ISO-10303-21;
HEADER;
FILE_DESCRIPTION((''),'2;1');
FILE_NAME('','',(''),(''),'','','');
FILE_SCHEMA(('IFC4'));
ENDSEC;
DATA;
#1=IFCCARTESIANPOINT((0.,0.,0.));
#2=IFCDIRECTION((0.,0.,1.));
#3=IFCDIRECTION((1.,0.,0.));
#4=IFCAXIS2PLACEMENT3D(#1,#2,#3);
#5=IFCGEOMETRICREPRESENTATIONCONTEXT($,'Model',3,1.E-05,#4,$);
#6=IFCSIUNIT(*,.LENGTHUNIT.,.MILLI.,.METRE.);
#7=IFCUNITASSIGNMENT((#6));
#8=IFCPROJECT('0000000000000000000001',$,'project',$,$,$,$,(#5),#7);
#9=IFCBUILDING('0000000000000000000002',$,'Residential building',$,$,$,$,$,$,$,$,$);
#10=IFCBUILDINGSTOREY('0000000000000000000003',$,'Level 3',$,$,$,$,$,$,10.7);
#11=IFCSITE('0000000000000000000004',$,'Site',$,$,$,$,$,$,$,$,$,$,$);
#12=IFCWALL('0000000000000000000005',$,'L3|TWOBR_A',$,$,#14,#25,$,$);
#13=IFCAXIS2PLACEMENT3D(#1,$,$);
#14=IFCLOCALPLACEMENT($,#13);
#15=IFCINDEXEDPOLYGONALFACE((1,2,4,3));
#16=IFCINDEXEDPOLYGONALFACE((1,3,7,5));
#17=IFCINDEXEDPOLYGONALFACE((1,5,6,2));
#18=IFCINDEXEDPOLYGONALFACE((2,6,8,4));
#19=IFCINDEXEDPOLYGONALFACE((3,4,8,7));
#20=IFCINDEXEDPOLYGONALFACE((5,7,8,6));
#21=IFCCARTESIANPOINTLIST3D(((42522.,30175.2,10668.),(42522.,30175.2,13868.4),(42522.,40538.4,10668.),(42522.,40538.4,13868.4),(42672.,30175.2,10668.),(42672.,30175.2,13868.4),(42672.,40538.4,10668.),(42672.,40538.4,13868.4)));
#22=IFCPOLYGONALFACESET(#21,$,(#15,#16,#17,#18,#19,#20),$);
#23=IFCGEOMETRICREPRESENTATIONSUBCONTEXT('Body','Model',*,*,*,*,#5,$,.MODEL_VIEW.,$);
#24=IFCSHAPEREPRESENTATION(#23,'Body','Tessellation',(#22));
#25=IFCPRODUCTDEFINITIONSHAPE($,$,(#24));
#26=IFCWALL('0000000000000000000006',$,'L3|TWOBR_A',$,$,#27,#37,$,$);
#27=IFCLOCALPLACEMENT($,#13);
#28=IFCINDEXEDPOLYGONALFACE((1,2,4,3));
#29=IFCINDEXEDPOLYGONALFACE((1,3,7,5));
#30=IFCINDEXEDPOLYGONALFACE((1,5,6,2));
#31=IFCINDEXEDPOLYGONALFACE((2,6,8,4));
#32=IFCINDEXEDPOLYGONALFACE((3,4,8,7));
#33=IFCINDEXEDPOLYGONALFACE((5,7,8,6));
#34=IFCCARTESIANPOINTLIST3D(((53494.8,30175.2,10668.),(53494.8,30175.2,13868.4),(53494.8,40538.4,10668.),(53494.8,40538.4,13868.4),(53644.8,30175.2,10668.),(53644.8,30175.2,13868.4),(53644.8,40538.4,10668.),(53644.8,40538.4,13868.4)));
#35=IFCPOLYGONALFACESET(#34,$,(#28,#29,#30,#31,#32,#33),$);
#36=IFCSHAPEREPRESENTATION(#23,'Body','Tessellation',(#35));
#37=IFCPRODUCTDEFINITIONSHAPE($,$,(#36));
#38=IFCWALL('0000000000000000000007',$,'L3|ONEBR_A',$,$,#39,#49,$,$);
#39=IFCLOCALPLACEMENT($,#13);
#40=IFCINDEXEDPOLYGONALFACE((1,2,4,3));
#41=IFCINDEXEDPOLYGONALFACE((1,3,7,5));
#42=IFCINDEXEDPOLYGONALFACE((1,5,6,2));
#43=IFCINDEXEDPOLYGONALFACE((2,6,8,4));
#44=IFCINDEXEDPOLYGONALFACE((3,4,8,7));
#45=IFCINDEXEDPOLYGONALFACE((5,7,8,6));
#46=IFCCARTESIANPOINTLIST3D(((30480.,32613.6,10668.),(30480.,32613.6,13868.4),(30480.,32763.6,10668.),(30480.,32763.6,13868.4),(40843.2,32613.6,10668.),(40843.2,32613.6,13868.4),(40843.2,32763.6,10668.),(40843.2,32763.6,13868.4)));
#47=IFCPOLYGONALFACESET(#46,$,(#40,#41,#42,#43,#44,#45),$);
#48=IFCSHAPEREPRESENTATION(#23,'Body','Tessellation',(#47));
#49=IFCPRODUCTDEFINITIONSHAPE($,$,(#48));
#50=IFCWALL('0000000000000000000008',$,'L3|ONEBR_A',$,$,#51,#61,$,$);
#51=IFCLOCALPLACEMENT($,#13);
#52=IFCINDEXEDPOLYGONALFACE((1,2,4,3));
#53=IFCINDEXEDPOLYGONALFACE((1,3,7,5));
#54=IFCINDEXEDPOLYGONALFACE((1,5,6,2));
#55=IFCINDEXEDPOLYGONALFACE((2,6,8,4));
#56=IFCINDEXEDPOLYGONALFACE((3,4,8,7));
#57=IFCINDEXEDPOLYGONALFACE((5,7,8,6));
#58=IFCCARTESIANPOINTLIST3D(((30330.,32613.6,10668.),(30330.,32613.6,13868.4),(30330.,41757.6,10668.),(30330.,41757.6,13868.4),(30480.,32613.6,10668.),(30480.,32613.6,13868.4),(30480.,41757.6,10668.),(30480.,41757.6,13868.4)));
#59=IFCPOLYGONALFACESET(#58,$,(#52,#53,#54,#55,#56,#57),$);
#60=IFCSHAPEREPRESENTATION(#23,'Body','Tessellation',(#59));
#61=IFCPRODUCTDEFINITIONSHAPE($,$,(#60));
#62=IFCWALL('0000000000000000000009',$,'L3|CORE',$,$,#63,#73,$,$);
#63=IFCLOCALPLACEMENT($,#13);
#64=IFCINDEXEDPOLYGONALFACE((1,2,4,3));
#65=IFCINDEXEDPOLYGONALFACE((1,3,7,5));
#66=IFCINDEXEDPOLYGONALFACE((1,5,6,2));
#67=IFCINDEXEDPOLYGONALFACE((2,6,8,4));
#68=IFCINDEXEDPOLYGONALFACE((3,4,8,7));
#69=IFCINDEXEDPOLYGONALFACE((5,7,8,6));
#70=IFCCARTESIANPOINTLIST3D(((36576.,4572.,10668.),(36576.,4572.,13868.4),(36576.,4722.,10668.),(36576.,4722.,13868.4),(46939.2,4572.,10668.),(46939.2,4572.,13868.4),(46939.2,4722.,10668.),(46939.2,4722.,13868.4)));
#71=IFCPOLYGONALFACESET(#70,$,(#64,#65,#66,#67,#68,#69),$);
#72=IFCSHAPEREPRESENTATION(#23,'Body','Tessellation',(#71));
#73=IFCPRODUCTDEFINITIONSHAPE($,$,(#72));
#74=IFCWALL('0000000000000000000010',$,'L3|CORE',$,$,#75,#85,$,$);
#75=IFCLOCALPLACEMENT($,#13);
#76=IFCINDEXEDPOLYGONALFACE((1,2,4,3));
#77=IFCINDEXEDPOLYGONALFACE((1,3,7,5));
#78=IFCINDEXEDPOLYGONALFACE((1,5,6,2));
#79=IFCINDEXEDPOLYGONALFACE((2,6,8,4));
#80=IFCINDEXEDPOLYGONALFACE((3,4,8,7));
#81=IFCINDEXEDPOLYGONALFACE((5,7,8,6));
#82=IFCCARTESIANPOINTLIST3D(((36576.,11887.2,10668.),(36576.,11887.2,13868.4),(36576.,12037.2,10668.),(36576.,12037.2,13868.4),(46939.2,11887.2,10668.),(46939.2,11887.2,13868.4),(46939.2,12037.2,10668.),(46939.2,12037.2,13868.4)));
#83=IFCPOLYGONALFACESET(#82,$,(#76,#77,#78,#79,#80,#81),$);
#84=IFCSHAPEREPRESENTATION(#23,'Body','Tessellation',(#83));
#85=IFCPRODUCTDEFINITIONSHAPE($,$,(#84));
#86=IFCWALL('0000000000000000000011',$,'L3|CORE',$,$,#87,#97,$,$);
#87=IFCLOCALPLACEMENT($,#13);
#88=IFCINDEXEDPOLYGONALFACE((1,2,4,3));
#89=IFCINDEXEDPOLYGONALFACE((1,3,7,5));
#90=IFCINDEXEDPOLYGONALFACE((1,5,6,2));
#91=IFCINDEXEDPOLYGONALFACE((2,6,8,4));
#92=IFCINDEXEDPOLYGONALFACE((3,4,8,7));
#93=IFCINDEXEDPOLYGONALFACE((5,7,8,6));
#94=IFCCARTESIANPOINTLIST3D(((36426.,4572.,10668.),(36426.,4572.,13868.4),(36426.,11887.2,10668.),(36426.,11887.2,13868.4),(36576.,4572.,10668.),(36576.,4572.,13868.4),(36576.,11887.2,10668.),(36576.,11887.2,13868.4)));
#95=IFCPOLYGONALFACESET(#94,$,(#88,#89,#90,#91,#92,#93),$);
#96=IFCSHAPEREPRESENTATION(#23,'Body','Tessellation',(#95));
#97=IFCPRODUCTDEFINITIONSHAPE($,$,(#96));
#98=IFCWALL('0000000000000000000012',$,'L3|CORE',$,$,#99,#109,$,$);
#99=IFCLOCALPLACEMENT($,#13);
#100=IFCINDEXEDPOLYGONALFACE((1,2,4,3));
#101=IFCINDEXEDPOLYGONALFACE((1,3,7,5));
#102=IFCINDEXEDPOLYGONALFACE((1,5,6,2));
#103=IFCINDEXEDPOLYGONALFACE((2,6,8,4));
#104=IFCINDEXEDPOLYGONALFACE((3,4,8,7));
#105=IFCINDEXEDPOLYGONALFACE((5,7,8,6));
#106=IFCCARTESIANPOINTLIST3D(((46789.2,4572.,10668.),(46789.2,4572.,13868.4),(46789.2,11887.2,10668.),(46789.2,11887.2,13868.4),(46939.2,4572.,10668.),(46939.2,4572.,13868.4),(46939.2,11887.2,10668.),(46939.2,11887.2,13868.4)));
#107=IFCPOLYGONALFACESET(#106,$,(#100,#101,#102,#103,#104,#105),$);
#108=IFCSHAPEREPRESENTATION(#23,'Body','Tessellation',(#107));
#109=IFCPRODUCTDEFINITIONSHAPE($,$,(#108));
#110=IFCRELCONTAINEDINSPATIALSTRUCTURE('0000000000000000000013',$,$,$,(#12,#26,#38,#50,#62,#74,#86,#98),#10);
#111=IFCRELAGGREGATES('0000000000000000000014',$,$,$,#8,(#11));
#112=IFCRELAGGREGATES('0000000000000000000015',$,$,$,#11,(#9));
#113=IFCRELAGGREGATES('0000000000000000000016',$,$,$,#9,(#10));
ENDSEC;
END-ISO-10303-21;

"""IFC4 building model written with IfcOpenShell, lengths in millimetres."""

from ifc_helpers import new_model, si_unit, frame, origin_with_axes, place, context, subcontext, project, spatial, indexed_curve, outline, extrude, element, save


model = new_model("IFC4")

# Units and contexts
model_context = context("Model", 3, precision=1e-05, world=origin_with_axes())
body_context = subcontext(model_context, "Body", "Model", "MODEL_VIEW")
ifc_project = project(units=[si_unit("LENGTHUNIT", "METRE", prefix="MILLI")], contexts=[model_context])

# Site, building, storey
site = spatial("IfcSite", under=ifc_project, Name="Site")
building = spatial("IfcBuilding", under=site, Name="Residential building")
storey = spatial("IfcBuildingStorey", under=building, Name="Level 3", Elevation=10.7)

# Walls
for number, where, z_axis, x_axis, name in (
    (1, (42672.0, 30175.2, 10668.0), (0.0, 0.0, 1.0), (0.0, 1.0, 0.0), "L3|TWOBR_A"),
    (2, (53644.8, 30175.2, 10668.0), (0.0, 0.0, 1.0), (0.0, 1.0, 0.0), "L3|TWOBR_A"),
    (3, (30480.0, 32613.6, 10668.0), (0.0, 0.0, 1.0), (1.0, 0.0, 0.0), "L3|ONEBR_A"),
):
    element("IfcWall", number, at=place(None, frame(where, z_axis=z_axis, x_axis=x_axis)), inside=storey, Name=name, context=body_context, shape_type="SweptSolid", body=[
        extrude(outline(indexed_curve([(0.0, 0.0), (0.0, 150.0), (10363.2, 150.0), (10363.2, 0.0), (0.0, 0.0)], self_intersect=False)), origin_with_axes(), (0.0, 0.0, 1.0), 3200.4),
    ])
wall_1_placement = place(None, frame((30480.0, 32613.6, 10668.0), z_axis=(0.0, 0.0, 1.0), x_axis=(0.0, 1.0, 0.0)))
element("IfcWall", 4, at=wall_1_placement, inside=storey, Name="L3|ONEBR_A", context=body_context, shape_type="SweptSolid", body=[
    extrude(outline(indexed_curve([(0.0, 0.0), (0.0, 150.0), (9144.0, 150.0), (9144.0, 0.0), (0.0, 0.0)], self_intersect=False)), origin_with_axes(), (0.0, 0.0, 1.0), 3200.4),
])
for number, where, z_axis, x_axis, name in (
    (5, (36576.0, 4572.0, 10668.0), (0.0, 0.0, 1.0), (1.0, 0.0, 0.0), "L3|CORE"),
    (6, (36576.0, 11887.2, 10668.0), (0.0, 0.0, 1.0), (1.0, 0.0, 0.0), "L3|CORE"),
):
    element("IfcWall", number, at=place(None, frame(where, z_axis=z_axis, x_axis=x_axis)), inside=storey, Name=name, context=body_context, shape_type="SweptSolid", body=[
        extrude(outline(indexed_curve([(0.0, 0.0), (0.0, 150.0), (10363.2, 150.0), (10363.2, 0.0), (0.0, 0.0)], self_intersect=False)), origin_with_axes(), (0.0, 0.0, 1.0), 3200.4),
    ])
for number, where, z_axis, x_axis, name in (
    (7, (36576.0, 4572.0, 10668.0), (0.0, 0.0, 1.0), (0.0, 1.0, 0.0), "L3|CORE"),
    (8, (46939.2, 4572.0, 10668.0), (0.0, 0.0, 1.0), (0.0, 1.0, 0.0), "L3|CORE"),
):
    element("IfcWall", number, at=place(None, frame(where, z_axis=z_axis, x_axis=x_axis)), inside=storey, Name=name, context=body_context, shape_type="SweptSolid", body=[
        extrude(outline(indexed_curve([(0.0, 0.0), (0.0, 150.0), (7315.2, 150.0), (7315.2, 0.0), (0.0, 0.0)], self_intersect=False)), origin_with_axes(), (0.0, 0.0, 1.0), 3200.4),
    ])

save(model, "model.ifc")
